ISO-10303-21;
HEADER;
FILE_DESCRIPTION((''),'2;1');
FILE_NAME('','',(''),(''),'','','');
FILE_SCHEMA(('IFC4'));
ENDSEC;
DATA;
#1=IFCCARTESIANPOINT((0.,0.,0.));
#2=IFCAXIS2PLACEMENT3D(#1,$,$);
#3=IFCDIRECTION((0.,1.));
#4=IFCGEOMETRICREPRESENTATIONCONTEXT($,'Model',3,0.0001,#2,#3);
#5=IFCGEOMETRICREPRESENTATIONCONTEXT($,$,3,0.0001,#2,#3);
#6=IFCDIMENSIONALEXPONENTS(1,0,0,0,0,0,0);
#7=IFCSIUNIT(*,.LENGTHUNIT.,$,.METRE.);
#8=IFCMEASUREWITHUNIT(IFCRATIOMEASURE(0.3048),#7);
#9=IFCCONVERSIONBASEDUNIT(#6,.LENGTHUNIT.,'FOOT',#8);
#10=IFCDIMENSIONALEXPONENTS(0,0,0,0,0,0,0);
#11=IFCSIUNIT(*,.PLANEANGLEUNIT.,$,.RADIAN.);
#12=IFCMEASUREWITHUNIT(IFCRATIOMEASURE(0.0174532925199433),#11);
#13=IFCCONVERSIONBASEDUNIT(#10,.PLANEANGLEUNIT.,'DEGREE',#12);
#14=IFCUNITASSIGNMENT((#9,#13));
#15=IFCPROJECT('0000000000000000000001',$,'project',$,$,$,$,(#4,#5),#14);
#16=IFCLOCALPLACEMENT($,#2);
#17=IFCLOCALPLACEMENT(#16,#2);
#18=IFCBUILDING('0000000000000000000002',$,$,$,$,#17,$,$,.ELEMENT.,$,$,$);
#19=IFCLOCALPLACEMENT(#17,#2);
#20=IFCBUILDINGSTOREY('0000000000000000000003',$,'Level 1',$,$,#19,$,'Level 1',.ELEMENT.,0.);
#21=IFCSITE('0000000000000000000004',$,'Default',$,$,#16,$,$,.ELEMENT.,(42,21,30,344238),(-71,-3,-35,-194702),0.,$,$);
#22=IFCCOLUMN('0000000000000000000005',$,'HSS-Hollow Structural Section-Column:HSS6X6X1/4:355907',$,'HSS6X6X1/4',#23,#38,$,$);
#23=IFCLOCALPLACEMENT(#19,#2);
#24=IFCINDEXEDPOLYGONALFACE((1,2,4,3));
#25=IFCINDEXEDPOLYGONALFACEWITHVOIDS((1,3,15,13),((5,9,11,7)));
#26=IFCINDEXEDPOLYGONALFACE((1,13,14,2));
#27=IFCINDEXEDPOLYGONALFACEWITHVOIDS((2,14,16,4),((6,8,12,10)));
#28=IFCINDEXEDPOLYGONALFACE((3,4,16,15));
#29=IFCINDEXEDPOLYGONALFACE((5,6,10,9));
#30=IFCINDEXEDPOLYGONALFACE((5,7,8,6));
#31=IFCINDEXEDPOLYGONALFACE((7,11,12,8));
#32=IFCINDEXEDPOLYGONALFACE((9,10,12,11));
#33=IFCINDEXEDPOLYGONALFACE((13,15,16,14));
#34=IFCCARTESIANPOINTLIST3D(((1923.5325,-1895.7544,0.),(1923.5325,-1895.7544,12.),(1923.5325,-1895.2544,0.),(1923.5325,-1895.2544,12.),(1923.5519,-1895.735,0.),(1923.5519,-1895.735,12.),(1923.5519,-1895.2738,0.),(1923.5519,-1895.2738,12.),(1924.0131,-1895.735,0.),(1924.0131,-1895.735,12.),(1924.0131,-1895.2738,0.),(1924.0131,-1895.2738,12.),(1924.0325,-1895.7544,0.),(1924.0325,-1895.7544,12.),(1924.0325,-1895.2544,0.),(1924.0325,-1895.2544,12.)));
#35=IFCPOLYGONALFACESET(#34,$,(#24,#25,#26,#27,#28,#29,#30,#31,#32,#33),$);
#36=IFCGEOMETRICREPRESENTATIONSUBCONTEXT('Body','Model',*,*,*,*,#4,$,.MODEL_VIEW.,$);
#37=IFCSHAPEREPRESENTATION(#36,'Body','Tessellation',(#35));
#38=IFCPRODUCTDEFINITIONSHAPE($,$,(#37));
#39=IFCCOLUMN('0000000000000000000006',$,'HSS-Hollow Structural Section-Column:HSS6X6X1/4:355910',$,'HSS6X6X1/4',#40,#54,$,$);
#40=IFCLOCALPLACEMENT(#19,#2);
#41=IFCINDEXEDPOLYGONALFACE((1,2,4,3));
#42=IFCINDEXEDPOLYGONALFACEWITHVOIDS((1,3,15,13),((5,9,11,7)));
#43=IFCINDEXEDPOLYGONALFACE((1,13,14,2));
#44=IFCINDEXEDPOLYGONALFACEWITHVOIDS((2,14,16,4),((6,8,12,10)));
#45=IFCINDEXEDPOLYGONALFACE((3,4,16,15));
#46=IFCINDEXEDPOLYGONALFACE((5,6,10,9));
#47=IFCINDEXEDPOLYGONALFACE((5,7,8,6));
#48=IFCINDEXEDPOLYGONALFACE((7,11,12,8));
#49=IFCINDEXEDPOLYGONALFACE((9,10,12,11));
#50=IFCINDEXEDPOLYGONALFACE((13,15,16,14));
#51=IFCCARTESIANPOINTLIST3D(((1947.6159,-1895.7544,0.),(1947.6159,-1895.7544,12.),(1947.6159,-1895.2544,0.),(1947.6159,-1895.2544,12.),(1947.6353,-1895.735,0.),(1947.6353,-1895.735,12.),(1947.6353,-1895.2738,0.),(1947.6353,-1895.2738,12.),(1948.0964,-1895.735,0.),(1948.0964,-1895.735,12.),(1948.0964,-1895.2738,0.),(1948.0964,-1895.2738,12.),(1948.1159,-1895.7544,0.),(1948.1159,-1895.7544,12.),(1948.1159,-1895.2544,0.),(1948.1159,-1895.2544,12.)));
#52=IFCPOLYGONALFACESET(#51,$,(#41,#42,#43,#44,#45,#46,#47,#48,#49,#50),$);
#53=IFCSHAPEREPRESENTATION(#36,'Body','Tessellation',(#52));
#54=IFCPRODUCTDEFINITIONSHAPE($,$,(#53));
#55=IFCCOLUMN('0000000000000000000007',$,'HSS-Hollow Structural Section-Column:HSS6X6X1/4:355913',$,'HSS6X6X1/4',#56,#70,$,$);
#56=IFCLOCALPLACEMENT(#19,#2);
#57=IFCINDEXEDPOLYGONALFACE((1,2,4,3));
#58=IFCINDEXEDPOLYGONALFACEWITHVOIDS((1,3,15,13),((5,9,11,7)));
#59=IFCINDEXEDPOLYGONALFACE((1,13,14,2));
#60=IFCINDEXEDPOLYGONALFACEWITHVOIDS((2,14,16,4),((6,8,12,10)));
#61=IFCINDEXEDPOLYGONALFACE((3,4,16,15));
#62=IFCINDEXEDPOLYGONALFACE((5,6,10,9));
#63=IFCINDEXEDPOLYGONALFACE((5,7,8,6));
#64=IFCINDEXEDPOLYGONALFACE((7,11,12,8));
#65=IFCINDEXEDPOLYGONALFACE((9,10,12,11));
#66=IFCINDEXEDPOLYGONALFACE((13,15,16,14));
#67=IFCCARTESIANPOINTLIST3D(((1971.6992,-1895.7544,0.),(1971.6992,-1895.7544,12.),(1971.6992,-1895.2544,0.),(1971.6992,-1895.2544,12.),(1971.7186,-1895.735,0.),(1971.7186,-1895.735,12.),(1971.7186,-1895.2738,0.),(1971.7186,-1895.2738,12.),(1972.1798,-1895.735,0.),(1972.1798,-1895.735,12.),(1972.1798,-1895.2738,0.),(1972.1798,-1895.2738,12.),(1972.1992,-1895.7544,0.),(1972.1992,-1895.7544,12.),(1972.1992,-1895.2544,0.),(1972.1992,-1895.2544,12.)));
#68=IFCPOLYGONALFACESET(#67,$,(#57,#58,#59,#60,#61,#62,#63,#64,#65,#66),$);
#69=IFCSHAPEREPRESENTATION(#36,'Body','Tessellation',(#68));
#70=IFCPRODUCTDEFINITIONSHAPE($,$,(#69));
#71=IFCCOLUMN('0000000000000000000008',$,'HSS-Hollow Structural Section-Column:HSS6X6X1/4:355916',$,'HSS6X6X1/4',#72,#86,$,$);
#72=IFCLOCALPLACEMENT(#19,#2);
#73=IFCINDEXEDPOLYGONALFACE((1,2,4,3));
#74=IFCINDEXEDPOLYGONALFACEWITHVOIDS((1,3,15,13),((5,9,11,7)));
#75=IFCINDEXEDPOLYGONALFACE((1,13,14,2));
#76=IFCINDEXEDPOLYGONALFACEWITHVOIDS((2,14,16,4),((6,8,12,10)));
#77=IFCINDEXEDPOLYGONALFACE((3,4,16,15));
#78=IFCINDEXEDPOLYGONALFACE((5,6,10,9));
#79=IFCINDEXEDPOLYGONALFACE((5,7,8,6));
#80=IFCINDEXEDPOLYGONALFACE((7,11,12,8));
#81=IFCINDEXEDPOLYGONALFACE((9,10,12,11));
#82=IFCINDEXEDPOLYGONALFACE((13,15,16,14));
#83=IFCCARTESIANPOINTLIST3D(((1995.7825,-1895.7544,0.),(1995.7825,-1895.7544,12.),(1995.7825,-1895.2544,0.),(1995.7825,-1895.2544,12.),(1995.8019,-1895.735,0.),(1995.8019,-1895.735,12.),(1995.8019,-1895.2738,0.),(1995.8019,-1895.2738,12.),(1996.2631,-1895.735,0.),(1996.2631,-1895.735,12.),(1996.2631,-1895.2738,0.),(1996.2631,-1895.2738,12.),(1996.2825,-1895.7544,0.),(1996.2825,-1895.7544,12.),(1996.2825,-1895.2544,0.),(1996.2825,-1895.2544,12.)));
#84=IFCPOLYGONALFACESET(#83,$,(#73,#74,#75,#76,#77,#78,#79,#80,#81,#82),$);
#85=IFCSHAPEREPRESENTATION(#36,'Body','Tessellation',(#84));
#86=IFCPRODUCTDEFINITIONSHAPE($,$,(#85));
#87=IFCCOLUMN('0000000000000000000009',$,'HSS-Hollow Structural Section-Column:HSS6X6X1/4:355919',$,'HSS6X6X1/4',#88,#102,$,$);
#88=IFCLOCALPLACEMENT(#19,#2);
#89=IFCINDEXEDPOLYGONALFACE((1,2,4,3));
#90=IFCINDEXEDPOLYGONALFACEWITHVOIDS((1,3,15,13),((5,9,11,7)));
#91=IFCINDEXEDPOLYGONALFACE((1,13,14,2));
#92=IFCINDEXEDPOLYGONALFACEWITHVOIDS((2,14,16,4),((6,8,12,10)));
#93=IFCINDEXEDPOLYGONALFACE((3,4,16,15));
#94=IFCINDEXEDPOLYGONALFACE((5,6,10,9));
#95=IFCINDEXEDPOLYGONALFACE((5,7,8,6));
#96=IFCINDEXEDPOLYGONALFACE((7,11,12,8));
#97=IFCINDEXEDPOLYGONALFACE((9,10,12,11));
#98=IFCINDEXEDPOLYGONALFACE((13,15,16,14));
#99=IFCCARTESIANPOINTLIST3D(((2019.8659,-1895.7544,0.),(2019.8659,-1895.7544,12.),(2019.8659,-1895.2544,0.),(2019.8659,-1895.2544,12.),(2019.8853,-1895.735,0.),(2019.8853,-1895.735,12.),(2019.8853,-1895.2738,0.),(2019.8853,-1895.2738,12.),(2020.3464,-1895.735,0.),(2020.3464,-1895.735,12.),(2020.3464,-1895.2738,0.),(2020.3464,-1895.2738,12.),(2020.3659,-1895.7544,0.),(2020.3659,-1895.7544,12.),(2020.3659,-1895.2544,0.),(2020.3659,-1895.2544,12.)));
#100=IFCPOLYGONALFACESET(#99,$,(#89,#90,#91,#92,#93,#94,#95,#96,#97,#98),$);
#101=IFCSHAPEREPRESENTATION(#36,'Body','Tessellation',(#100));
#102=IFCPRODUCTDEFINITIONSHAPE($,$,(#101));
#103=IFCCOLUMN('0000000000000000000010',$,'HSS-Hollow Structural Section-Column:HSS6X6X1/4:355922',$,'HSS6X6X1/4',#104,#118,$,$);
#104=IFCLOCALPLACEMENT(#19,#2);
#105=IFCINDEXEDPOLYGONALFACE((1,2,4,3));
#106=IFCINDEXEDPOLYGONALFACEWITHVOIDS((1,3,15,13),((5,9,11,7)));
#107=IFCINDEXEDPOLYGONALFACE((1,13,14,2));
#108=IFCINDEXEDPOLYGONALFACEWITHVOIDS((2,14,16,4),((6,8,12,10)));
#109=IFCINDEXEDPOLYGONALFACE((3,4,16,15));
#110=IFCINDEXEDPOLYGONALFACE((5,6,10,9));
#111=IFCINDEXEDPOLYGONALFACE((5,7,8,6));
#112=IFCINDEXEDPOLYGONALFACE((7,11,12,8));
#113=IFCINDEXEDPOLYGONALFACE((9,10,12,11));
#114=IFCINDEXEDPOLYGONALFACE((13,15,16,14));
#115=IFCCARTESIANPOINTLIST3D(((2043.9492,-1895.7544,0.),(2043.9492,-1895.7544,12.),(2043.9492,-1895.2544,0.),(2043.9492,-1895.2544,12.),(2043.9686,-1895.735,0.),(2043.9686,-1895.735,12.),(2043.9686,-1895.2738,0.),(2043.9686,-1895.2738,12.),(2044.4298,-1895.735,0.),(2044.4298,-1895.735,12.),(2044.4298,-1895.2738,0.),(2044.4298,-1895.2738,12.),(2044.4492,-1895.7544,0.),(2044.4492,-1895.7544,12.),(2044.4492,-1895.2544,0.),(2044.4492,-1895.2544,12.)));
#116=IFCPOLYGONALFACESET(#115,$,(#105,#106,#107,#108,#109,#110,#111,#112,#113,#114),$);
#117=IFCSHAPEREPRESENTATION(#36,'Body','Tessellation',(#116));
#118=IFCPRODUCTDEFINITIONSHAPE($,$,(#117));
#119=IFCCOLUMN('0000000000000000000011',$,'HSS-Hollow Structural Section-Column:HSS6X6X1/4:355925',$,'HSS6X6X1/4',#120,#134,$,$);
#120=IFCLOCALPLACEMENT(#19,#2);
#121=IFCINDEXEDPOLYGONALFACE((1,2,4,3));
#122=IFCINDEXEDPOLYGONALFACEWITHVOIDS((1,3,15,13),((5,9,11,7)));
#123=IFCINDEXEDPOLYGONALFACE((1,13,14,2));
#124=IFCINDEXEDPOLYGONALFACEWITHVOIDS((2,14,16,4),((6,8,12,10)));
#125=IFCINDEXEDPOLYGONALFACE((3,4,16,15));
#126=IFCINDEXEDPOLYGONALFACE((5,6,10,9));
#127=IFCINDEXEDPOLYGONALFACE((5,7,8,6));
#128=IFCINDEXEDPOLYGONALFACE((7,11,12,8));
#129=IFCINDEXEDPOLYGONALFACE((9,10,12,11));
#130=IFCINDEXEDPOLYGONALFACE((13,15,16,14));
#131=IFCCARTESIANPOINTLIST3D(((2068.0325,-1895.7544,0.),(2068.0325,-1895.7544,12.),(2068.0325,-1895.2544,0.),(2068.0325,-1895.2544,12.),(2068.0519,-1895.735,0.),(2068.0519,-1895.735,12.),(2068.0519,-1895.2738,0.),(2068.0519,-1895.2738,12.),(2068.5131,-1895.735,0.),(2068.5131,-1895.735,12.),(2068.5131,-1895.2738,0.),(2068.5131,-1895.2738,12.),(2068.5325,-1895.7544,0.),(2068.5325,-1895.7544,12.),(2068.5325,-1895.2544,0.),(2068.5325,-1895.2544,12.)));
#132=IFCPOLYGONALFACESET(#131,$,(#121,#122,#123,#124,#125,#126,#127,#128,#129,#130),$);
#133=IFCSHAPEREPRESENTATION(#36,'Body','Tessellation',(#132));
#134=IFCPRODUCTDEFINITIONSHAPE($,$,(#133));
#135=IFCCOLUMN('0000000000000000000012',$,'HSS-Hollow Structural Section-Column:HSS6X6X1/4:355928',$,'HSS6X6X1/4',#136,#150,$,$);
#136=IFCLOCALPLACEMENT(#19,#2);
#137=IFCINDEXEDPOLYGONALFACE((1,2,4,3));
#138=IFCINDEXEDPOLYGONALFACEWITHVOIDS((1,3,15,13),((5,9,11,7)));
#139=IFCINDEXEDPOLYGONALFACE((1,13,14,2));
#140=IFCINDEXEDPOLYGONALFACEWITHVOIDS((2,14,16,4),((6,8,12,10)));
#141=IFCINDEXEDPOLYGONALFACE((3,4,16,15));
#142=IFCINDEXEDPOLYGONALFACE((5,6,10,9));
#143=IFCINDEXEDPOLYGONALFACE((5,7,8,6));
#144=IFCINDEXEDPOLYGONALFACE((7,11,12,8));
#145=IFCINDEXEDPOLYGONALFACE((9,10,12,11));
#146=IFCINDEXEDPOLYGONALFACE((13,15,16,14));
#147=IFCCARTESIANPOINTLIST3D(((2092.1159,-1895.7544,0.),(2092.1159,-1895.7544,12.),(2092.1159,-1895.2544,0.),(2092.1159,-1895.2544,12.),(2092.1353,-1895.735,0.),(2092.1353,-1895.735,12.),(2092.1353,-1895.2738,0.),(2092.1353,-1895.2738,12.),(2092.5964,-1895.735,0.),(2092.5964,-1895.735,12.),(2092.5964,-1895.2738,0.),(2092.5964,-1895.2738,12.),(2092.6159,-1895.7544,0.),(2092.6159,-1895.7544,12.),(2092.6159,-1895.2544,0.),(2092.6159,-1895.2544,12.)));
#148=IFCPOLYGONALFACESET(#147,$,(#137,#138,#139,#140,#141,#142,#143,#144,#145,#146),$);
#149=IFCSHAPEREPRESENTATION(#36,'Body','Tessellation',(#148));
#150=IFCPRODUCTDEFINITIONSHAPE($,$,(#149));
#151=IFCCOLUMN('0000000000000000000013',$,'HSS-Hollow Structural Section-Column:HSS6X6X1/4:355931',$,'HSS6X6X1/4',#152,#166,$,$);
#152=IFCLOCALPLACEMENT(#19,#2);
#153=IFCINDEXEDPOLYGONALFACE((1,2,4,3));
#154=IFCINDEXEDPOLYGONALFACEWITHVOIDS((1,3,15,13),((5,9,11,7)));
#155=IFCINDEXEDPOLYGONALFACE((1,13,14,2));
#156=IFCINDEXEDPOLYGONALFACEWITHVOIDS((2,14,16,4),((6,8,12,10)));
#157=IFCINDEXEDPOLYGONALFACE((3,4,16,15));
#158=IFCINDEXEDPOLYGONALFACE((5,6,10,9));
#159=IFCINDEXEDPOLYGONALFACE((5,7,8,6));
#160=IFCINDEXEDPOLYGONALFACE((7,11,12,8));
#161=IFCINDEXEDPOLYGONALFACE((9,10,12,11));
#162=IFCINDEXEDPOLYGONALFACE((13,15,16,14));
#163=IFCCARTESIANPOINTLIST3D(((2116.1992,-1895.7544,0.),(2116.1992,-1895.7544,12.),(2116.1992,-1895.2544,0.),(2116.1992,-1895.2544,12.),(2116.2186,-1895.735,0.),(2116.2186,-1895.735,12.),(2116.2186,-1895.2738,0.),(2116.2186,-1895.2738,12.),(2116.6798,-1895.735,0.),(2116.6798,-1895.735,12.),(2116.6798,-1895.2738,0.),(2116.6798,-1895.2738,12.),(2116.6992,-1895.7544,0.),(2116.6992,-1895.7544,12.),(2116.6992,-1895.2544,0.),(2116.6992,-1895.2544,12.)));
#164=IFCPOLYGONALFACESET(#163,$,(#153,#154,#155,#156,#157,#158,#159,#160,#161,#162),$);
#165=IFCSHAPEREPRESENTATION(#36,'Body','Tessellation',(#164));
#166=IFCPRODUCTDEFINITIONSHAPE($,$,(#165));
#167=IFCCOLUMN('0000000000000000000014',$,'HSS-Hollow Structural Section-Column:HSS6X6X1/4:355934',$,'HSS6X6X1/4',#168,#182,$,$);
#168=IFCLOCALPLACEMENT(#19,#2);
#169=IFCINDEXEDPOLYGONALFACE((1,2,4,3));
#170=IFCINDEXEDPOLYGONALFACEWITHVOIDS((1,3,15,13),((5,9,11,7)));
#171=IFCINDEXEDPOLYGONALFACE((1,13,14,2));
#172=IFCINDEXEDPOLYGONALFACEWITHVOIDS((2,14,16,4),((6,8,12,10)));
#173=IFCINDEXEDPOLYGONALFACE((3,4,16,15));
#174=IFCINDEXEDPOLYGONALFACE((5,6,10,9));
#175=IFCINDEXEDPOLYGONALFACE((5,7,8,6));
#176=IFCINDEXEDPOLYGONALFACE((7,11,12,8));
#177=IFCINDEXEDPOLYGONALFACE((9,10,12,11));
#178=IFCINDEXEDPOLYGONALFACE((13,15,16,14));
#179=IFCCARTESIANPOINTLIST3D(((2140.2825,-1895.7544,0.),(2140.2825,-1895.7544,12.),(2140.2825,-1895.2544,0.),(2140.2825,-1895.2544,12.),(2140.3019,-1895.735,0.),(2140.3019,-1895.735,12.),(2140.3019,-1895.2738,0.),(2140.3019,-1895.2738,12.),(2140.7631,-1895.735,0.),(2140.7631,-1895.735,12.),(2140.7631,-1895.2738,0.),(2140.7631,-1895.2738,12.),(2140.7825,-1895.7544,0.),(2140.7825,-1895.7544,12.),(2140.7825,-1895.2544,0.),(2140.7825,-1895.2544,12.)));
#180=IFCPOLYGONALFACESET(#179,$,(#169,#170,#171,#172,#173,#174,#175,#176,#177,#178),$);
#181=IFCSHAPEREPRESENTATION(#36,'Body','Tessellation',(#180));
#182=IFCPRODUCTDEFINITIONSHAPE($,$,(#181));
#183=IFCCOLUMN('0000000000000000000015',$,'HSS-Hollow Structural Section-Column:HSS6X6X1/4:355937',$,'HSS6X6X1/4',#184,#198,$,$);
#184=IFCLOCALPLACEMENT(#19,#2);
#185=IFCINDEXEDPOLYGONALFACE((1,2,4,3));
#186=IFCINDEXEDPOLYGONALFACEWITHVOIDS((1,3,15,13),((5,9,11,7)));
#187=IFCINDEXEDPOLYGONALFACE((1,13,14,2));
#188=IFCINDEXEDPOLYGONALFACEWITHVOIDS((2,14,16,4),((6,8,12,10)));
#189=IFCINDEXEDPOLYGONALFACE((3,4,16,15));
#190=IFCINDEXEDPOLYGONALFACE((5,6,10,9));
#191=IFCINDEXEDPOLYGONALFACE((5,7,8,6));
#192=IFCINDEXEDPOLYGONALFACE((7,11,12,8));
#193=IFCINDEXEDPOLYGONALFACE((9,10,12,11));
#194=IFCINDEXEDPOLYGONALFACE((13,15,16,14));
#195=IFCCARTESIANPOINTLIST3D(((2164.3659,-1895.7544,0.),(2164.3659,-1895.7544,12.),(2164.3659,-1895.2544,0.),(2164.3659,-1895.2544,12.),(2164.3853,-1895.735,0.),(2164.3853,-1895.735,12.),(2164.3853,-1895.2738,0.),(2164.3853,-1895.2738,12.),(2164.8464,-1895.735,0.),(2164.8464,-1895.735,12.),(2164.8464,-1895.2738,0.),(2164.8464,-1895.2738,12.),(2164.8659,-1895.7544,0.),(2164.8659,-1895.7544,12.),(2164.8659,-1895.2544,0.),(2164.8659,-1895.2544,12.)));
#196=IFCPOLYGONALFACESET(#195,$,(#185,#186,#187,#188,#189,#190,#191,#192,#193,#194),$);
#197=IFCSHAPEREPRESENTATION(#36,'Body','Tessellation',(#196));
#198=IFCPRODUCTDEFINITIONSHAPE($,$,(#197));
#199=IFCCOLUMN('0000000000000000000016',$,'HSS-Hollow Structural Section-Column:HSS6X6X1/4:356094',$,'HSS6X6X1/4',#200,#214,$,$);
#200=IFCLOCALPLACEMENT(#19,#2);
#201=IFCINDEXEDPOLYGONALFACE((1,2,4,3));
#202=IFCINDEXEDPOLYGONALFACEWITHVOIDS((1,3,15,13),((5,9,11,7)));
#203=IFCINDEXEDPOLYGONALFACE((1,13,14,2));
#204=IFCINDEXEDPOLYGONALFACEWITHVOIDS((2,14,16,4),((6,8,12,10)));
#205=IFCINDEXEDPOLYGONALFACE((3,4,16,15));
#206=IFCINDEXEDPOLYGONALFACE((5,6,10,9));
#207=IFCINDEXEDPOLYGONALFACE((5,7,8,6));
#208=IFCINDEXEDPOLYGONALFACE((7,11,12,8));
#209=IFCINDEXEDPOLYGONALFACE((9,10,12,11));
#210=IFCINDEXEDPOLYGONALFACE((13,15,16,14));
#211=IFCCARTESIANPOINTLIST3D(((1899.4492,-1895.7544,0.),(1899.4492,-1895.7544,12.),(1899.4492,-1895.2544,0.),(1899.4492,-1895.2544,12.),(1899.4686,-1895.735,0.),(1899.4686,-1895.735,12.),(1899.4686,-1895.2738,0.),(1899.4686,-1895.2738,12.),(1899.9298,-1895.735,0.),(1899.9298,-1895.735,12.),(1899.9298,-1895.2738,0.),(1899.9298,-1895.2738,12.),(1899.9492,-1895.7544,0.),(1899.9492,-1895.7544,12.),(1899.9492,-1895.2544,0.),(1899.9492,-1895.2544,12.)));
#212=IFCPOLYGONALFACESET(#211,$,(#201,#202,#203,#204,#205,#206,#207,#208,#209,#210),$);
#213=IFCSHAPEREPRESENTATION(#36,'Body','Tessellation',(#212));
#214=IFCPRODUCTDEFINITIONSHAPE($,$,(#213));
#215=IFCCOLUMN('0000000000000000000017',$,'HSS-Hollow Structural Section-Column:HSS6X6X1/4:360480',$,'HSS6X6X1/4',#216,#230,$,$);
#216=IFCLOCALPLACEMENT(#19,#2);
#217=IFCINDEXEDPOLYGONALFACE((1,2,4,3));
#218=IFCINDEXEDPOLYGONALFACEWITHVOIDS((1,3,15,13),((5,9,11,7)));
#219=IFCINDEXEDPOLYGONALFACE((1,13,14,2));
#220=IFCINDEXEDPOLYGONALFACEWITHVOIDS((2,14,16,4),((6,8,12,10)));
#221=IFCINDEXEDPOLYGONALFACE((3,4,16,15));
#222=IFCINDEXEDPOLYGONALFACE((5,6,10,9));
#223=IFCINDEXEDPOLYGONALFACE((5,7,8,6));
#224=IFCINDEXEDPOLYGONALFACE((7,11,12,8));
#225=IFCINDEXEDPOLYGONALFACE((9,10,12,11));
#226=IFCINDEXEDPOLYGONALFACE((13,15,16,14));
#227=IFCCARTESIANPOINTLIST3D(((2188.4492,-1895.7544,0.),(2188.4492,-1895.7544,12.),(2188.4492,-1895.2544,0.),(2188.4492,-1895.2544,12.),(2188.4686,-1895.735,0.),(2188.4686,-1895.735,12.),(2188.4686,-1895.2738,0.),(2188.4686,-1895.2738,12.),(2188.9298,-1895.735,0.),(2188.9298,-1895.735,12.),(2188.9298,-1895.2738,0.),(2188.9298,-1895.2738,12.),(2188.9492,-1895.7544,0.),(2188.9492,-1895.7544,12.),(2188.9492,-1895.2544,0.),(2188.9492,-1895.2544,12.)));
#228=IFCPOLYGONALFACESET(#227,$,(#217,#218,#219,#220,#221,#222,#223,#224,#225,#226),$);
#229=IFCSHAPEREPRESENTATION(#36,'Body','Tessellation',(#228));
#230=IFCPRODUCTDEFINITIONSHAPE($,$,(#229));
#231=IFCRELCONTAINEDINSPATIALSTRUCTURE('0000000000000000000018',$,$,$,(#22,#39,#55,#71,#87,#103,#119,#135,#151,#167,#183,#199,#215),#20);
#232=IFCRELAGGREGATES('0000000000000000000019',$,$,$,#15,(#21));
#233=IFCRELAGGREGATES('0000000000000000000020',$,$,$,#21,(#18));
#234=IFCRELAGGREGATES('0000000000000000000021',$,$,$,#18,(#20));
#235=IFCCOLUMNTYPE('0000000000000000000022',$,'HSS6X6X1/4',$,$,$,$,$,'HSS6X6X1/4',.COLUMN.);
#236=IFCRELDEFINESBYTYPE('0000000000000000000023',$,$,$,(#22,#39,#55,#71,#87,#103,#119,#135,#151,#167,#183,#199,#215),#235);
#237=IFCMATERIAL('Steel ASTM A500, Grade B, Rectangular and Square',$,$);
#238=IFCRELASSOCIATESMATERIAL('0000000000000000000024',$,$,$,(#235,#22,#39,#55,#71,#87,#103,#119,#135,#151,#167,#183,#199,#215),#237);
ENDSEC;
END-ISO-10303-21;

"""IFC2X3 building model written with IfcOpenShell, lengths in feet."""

from ifc_helpers import new_model, entity, si_unit, converted_unit, direction, frame, origin, place, context, subcontext, project, spatial, polyline, outline, extrude, source, transform, mapped, material, type_object, type_shapes, element, save


model = new_model("IFC2X3")

# Units and contexts
model_context = context("Model", 3, precision=0.0001, world=origin(), true_north=direction((0.0, 1.0)))
context_of_model = context(None, 3, precision=0.0001, world=origin(), true_north=direction((0.0, 1.0)))
body_context = subcontext(model_context, "Body", "Model", "MODEL_VIEW")
ifc_project = project(units=[converted_unit("LENGTHUNIT", "FOOT", entity("IfcRatioMeasure", 0.3048), si_unit("LENGTHUNIT", "METRE"), dimensions=[1, 0, 0, 0, 0, 0, 0]), converted_unit("PLANEANGLEUNIT", "DEGREE", entity("IfcRatioMeasure", 0.0174532925199433), si_unit("PLANEANGLEUNIT", "RADIAN"), dimensions=[0, 0, 0, 0, 0, 0, 0])], contexts=[model_context, context_of_model])

# Site, building, storey
site_placement = place(None, origin())
site = spatial("IfcSite", under=ifc_project, at=site_placement, Name="Default", CompositionType="ELEMENT", RefLatitude=(42, 21, 30, 344238), RefLongitude=(-71, -3, -35, -194702), RefElevation=0.0)
building_placement = place(site_placement, origin())
building = spatial("IfcBuilding", under=site, at=building_placement, CompositionType="ELEMENT")
storey_placement = place(building_placement, origin())
storey = spatial("IfcBuildingStorey", under=building, at=storey_placement, Name="Level 1", LongName="Level 1", CompositionType="ELEMENT", Elevation=0.0)

# Columns
ifc_material_1 = material(Name="Steel ASTM A500, Grade B, Rectangular and Square")
column_type_1 = type_object("IfcColumnType", Name="HSS6X6X1/4", ElementType="HSS6X6X1/4", PredefinedType="COLUMN", material=ifc_material_1)
shared_shape_1 = source(origin(), body_context, "Body", "SweptSolid", [
    extrude(outline(polyline([(-0.25, -0.25), (0.25, -0.25), (0.25, 0.25), (-0.25, 0.25), (-0.25, -0.25)]), holes=[polyline([(-0.2306, -0.2306), (-0.2306, 0.2306), (0.2306, 0.2306), (0.2306, -0.2306), (-0.2306, -0.2306)])]), frame((0.0, 0.0, 0.0), z_axis=(0.0, 0.0, 1.0), x_axis=(-1.0, 0.0, 0.0)), (0.0, 0.0, 1.0), 12.0),
])
type_shapes(column_type_1, [shared_shape_1])
for number, where, z_axis, x_axis, name in (
    (1, (1923.7825, -1895.5044, 0.0), (0.0, 0.0, 1.0), (-1.0, 0.0, 0.0), "HSS-Hollow Structural Section-Column:HSS6X6X1/4:355907"),
    (2, (1947.8659, -1895.5044, 0.0), (0.0, 0.0, 1.0), (-1.0, 0.0, 0.0), "HSS-Hollow Structural Section-Column:HSS6X6X1/4:355910"),
    (3, (1971.9492, -1895.5044, 0.0), (0.0, 0.0, 1.0), (-1.0, 0.0, 0.0), "HSS-Hollow Structural Section-Column:HSS6X6X1/4:355913"),
    (4, (1996.0325, -1895.5044, 0.0), (0.0, 0.0, 1.0), (-1.0, 0.0, 0.0), "HSS-Hollow Structural Section-Column:HSS6X6X1/4:355916"),
    (5, (2020.1159, -1895.5044, 0.0), (0.0, 0.0, 1.0), (-1.0, 0.0, 0.0), "HSS-Hollow Structural Section-Column:HSS6X6X1/4:355919"),
    (6, (2044.1992, -1895.5044, 0.0), (0.0, 0.0, 1.0), (-1.0, 0.0, 0.0), "HSS-Hollow Structural Section-Column:HSS6X6X1/4:355922"),
    (7, (2068.2825, -1895.5044, 0.0), (0.0, 0.0, 1.0), (-1.0, 0.0, 0.0), "HSS-Hollow Structural Section-Column:HSS6X6X1/4:355925"),
    (8, (2092.3659, -1895.5044, 0.0), (0.0, 0.0, 1.0), (-1.0, 0.0, 0.0), "HSS-Hollow Structural Section-Column:HSS6X6X1/4:355928"),
    (9, (2116.4492, -1895.5044, 0.0), (0.0, 0.0, 1.0), (-1.0, 0.0, 0.0), "HSS-Hollow Structural Section-Column:HSS6X6X1/4:355931"),
    (10, (2140.5325, -1895.5044, 0.0), (0.0, 0.0, 1.0), (-1.0, 0.0, 0.0), "HSS-Hollow Structural Section-Column:HSS6X6X1/4:355934"),
    (11, (2164.6159, -1895.5044, 0.0), (0.0, 0.0, 1.0), (-1.0, 0.0, 0.0), "HSS-Hollow Structural Section-Column:HSS6X6X1/4:355937"),
    (12, (1899.6992, -1895.5044, 0.0), (0.0, 0.0, 1.0), (-1.0, 0.0, 0.0), "HSS-Hollow Structural Section-Column:HSS6X6X1/4:356094"),
    (13, (2188.6992, -1895.5044, 0.0), (0.0, 0.0, 1.0), (-1.0, 0.0, 0.0), "HSS-Hollow Structural Section-Column:HSS6X6X1/4:360480"),
):
    element("IfcColumn", number, at=place(storey_placement, frame(where, z_axis=z_axis, x_axis=x_axis)), inside=storey, type_object=column_type_1, material=ifc_material_1, Name=name, ObjectType="HSS6X6X1/4", context=body_context, shape_type="MappedRepresentation", body=[
        mapped(shared_shape_1, transform((0.0, 0.0, 0.0), scale=1.0)),
    ])

save(model, "model.ifc")
